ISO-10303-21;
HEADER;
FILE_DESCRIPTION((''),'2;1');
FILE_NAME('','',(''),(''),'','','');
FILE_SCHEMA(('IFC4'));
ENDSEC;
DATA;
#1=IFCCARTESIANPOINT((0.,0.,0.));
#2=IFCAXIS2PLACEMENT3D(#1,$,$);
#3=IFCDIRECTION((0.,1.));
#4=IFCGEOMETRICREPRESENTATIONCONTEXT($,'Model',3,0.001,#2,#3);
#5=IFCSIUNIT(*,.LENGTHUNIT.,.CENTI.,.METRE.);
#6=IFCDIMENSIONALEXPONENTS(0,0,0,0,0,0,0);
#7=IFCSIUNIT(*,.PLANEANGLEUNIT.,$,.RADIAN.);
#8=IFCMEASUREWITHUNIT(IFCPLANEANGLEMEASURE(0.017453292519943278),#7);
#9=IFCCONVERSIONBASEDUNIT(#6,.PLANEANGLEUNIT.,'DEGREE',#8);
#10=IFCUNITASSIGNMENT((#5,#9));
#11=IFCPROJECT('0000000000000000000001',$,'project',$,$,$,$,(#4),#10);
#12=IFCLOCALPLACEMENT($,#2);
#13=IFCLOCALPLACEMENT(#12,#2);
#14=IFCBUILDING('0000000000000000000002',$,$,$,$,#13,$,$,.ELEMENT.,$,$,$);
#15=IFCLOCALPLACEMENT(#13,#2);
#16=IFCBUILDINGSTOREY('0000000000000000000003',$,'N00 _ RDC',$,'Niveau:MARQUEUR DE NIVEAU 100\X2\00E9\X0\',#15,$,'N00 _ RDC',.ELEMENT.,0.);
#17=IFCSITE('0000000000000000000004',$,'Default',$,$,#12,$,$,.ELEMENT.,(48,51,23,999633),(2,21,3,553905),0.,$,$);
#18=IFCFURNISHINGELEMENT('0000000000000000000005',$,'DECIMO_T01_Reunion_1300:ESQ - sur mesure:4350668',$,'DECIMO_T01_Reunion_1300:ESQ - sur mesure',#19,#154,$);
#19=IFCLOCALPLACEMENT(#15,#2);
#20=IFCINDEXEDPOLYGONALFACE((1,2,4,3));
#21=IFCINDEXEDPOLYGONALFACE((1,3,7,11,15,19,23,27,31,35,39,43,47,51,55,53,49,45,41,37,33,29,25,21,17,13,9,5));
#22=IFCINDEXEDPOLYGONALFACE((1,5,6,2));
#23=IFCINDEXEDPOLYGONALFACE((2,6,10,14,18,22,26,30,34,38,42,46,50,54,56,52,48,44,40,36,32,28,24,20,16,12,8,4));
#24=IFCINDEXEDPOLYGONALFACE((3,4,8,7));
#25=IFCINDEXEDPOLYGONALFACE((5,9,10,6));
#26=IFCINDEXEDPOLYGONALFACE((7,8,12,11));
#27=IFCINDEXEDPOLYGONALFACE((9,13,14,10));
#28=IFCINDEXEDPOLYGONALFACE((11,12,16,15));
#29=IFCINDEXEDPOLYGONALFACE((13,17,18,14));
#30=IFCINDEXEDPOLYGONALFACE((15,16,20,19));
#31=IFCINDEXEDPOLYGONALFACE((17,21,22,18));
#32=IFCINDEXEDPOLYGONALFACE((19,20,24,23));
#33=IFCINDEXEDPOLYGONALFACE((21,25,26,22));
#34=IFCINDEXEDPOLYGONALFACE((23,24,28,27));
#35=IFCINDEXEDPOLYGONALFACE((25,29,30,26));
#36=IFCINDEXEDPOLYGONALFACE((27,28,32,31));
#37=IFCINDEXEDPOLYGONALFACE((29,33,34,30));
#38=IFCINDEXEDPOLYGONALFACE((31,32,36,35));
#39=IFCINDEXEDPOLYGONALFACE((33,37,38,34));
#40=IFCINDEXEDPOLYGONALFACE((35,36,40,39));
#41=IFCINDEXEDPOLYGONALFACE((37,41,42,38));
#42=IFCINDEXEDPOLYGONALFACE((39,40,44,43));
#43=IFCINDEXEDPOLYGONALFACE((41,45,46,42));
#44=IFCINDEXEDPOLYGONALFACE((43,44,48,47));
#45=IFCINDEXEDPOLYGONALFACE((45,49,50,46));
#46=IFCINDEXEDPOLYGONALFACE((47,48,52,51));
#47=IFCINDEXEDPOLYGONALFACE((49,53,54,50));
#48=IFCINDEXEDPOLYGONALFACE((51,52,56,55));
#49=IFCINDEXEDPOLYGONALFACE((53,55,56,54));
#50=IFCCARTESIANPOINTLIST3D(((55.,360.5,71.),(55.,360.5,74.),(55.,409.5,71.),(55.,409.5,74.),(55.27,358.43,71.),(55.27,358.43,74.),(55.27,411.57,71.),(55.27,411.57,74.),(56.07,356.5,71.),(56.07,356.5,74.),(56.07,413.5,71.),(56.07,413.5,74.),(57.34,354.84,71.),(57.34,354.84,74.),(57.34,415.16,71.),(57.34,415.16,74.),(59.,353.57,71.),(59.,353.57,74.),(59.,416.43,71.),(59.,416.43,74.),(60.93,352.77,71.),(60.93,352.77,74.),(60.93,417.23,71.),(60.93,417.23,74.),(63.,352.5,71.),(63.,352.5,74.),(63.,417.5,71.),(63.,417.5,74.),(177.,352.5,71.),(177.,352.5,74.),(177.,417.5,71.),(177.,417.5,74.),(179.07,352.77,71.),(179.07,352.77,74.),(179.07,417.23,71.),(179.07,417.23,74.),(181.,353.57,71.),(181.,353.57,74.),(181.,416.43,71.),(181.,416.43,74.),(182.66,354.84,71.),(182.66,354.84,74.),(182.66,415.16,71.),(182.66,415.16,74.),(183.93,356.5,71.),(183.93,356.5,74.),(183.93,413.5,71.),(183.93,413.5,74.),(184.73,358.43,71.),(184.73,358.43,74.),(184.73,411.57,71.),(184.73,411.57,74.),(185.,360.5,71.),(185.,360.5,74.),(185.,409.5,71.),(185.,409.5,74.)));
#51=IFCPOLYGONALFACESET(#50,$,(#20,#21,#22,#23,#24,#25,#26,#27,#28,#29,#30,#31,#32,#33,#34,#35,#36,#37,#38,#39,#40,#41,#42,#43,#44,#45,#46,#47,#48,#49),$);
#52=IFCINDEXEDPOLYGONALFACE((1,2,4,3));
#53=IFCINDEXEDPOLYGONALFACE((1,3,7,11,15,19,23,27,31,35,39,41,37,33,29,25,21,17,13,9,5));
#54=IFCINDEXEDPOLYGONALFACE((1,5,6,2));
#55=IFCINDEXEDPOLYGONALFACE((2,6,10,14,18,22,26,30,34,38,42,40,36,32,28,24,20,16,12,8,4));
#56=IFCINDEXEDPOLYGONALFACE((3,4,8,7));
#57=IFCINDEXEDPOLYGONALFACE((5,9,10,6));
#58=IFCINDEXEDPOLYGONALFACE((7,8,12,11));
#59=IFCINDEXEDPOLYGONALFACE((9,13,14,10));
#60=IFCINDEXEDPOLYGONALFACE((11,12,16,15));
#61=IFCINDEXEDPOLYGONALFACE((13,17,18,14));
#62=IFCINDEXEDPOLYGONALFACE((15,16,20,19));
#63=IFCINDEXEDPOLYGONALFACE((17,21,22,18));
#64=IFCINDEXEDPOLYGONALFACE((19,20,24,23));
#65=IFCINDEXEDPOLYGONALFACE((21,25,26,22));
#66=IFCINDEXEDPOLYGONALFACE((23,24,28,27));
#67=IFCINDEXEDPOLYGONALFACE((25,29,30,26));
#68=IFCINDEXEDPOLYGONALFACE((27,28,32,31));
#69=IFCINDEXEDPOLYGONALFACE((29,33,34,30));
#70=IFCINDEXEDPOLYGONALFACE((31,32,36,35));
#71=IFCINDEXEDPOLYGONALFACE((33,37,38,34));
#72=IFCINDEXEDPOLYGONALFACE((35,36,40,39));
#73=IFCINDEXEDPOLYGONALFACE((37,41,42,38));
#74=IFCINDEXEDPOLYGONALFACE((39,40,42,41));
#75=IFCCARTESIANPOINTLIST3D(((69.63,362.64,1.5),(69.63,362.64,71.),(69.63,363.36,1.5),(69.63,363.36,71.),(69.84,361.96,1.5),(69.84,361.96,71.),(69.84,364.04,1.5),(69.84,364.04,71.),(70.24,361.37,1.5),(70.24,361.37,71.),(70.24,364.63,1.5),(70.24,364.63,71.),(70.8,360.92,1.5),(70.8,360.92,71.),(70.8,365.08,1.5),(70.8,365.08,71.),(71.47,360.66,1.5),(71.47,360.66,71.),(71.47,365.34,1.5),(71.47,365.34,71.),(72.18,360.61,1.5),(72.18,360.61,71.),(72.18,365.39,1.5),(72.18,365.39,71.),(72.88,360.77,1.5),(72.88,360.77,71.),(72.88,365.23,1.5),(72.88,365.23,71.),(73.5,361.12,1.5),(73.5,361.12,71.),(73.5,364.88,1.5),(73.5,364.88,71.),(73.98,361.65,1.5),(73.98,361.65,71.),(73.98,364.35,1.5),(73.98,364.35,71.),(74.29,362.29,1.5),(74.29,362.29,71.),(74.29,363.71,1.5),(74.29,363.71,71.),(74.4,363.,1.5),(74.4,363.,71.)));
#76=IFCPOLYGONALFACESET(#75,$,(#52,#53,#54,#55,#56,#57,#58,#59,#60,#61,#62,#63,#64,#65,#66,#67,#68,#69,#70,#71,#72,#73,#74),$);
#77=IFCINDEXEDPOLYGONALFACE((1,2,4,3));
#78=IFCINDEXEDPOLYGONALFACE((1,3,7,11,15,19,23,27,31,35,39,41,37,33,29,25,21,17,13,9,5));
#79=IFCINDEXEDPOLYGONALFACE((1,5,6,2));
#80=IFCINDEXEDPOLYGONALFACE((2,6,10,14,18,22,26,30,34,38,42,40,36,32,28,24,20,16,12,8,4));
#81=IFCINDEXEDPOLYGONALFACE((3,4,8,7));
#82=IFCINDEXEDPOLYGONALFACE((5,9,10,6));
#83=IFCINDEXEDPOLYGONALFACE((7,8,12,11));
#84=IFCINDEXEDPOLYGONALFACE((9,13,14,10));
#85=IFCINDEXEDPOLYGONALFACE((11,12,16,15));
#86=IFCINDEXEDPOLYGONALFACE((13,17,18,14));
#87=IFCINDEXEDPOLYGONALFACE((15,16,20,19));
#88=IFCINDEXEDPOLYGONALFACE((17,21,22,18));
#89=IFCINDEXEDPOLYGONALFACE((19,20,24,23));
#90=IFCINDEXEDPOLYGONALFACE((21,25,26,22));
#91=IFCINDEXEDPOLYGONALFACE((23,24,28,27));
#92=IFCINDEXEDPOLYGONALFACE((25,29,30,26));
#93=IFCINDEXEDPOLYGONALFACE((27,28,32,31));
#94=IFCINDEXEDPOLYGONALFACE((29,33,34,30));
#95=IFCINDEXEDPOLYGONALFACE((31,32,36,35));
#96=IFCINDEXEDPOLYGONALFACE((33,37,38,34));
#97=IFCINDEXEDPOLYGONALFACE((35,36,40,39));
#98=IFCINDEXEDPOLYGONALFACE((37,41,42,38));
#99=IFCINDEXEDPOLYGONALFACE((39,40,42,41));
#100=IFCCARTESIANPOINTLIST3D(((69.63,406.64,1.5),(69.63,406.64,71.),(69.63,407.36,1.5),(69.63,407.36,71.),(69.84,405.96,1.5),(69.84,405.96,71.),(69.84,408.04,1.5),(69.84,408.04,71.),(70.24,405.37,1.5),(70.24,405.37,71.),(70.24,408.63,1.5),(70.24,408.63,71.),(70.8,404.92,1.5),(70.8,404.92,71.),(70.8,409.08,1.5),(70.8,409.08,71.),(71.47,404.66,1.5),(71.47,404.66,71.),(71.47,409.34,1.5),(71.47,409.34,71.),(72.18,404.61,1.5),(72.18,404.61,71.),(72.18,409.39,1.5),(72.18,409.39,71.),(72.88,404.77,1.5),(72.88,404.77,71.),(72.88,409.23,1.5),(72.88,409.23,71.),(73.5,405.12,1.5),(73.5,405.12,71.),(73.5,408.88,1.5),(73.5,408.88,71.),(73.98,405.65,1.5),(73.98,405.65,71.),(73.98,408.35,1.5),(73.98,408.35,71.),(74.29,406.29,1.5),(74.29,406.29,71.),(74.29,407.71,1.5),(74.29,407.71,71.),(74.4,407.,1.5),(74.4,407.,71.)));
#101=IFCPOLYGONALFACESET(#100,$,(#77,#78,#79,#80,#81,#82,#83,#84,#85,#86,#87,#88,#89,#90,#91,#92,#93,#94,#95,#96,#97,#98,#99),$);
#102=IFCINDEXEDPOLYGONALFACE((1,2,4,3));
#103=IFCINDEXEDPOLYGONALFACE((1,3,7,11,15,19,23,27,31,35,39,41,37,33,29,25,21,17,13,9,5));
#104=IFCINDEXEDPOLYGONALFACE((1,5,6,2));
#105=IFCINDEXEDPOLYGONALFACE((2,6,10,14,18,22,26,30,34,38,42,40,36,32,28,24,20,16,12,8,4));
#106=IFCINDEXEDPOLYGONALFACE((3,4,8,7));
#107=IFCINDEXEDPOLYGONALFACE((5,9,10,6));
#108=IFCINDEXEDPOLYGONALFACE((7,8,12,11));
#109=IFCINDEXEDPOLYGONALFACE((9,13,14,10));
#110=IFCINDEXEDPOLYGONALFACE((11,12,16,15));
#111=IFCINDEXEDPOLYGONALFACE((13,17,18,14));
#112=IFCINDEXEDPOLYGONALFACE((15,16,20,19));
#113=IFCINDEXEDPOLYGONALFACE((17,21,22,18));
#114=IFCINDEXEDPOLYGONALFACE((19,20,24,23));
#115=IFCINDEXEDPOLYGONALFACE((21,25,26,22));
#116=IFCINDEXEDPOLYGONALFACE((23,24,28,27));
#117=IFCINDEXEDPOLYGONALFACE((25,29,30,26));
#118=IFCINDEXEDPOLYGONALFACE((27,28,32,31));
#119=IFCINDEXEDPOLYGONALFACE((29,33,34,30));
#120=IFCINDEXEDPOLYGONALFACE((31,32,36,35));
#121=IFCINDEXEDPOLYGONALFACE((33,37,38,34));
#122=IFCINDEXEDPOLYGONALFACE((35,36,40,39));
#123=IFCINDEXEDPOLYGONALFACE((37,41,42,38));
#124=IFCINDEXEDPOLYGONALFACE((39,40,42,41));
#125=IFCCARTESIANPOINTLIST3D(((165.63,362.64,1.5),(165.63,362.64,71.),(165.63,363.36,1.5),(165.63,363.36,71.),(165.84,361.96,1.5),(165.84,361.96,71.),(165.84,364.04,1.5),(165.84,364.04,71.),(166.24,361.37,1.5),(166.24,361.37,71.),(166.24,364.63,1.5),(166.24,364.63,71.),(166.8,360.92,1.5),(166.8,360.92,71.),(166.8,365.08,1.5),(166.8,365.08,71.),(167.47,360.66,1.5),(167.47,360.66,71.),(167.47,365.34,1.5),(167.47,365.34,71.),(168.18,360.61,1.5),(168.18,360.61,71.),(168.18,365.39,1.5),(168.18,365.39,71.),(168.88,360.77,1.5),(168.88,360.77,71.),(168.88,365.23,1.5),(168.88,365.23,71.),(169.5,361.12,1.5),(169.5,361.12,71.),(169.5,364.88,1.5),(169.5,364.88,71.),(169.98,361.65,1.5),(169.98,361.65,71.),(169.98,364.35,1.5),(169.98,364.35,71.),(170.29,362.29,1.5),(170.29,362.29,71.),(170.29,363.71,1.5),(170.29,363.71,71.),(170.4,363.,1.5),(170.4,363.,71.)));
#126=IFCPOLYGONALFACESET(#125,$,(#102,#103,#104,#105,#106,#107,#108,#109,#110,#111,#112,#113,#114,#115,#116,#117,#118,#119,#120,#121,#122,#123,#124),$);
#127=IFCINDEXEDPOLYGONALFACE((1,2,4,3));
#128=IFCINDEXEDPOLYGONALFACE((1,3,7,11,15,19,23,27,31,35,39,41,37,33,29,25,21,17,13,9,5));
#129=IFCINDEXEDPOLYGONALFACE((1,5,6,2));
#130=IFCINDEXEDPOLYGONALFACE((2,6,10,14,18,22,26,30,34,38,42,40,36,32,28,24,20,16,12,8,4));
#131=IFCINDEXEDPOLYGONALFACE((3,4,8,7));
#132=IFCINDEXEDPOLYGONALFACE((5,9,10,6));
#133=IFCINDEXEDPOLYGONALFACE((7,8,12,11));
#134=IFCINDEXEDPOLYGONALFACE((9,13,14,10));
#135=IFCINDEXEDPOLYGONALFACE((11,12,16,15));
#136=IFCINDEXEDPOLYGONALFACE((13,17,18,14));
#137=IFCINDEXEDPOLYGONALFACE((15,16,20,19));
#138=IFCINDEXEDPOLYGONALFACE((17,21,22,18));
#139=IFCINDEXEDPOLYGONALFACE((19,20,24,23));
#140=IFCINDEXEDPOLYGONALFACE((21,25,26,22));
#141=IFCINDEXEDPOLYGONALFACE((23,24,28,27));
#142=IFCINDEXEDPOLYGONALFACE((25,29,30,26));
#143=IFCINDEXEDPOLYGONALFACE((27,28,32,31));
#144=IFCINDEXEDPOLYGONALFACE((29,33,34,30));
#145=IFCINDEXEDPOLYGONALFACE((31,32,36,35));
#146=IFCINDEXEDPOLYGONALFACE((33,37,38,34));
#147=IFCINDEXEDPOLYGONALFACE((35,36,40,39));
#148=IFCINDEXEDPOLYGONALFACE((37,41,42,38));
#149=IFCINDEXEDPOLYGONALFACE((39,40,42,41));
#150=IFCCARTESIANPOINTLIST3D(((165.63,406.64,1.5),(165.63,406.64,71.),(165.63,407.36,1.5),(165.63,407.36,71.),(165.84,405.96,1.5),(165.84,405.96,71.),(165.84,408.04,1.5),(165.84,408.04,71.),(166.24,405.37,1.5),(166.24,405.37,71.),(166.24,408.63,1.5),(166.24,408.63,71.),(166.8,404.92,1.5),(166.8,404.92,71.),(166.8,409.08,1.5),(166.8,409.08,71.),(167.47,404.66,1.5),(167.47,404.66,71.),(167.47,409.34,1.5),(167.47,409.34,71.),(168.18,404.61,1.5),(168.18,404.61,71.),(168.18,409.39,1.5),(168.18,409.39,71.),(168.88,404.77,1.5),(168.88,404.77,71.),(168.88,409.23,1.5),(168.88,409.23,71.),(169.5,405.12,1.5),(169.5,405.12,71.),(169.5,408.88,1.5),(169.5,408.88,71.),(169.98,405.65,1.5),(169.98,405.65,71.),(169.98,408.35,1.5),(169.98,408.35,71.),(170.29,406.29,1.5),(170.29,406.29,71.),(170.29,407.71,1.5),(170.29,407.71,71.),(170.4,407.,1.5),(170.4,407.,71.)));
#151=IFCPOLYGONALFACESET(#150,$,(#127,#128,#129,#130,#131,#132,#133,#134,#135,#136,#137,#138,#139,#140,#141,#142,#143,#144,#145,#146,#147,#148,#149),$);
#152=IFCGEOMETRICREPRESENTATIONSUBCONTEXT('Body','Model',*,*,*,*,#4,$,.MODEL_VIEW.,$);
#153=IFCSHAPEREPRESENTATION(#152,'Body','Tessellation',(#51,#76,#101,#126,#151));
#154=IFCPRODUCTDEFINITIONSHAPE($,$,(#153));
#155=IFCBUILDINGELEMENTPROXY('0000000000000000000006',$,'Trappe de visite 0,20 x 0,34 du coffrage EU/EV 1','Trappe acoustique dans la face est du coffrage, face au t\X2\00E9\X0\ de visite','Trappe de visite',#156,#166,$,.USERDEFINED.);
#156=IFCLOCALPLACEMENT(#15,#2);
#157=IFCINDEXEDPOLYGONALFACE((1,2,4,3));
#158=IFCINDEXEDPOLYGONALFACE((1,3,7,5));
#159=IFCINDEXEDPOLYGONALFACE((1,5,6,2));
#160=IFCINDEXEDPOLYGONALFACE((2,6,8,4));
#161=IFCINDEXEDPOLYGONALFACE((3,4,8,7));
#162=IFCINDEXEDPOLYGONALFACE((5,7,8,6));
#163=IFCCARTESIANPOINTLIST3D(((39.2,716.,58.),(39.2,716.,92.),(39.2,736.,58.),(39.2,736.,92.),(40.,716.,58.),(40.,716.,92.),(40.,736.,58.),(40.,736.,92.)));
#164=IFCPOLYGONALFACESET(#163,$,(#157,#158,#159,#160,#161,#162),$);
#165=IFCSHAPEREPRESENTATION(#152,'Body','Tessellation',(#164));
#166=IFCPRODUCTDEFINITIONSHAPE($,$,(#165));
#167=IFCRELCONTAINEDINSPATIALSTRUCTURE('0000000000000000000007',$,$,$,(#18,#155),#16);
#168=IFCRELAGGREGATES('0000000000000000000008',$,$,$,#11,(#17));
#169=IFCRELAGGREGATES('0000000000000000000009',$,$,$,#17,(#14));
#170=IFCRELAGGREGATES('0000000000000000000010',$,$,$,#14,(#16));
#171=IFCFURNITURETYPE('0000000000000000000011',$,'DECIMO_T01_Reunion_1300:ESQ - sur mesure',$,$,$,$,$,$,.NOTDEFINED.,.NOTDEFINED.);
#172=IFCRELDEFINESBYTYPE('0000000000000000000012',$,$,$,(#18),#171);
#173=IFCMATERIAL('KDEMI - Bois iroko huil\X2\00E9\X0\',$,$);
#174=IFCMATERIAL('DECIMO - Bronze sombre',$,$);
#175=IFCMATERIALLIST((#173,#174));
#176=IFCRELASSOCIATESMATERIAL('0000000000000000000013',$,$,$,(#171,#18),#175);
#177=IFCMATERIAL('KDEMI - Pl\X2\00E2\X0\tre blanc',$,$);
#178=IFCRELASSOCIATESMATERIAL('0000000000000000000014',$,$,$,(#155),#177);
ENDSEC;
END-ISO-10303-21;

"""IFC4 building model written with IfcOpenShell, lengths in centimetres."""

from ifc_helpers import new_model, entity, si_unit, converted_unit, direction, frame, frame_2d, origin, origin_with_axes, origin_2d_with_axis, place, context, subcontext, project, spatial, polyline, circle_curve, parameter, trimmed, segment, composite_curve, rectangle, circle, outline, extrude, source, transform, mapped, material, material_list, type_object, type_shapes, element, save


model = new_model("IFC4")

# Units and contexts
model_context = context("Model", 3, precision=0.001, world=origin(), true_north=direction((0.0, 1.0)))
body_context = subcontext(model_context, "Body", "Model", "MODEL_VIEW")
ifc_project = project(units=[si_unit("LENGTHUNIT", "METRE", prefix="CENTI"), converted_unit("PLANEANGLEUNIT", "DEGREE", entity("IfcPlaneAngleMeasure", 0.017453292519943278), si_unit("PLANEANGLEUNIT", "RADIAN"), dimensions=[0, 0, 0, 0, 0, 0, 0])], contexts=[model_context])

# Site, building, storey
site_placement = place(None, origin())
site = spatial("IfcSite", under=ifc_project, at=site_placement, Name="Default", CompositionType="ELEMENT", RefLatitude=(48, 51, 23, 999633), RefLongitude=(2, 21, 3, 553905), RefElevation=0.0)
building_placement = place(site_placement, origin())
building = spatial("IfcBuilding", under=site, at=building_placement, CompositionType="ELEMENT")
storey_placement = place(building_placement, origin())
storey = spatial("IfcBuildingStorey", under=building, at=storey_placement, Name="N00 _ RDC", ObjectType="Niveau:MARQUEUR DE NIVEAU 100é", LongName="N00 _ RDC", CompositionType="ELEMENT", Elevation=0.0)

# Furnishing element
ifc_material_1 = material(Name="KDEMI - Bois iroko huilé")
ifc_material_2 = material(Name="DECIMO - Bronze sombre")
ifc_material_list_1 = material_list([ifc_material_1, ifc_material_2])
furniture_type_1 = type_object("IfcFurnitureType", Name="DECIMO_T01_Reunion_1300:ESQ - sur mesure", AssemblyPlace="NOTDEFINED", material=ifc_material_list_1)
shared_shape_1 = source(origin(), body_context, "Body", "SweptSolid", [
    extrude(outline(composite_curve([segment(polyline([(-57.0, -32.5), (57.0, -32.5)]), True, "CONTINUOUS"), segment(trimmed(circle_curve(frame_2d((57.0, -24.5), x_axis=(1.0, 0.0)), 8.0), [parameter(270.0)], [parameter(0.0)], True, "PARAMETER"), True, "CONTINUOUS"), segment(polyline([(65.0, -24.5), (65.0, 24.5)]), True, "CONTINUOUS"), segment(trimmed(circle_curve(frame_2d((57.0, 24.5), x_axis=(1.0, 0.0)), 8.0), [parameter(0.0)], [parameter(90.0)], True, "PARAMETER"), True, "CONTINUOUS"), segment(polyline([(57.0, 32.5), (-57.0, 32.5)]), True, "CONTINUOUS"), segment(trimmed(circle_curve(frame_2d((-57.0, 24.5), x_axis=(1.0, 0.0)), 8.0), [parameter(90.0)], [parameter(180.0)], True, "PARAMETER"), True, "CONTINUOUS"), segment(polyline([(-65.0, 24.5), (-65.0, -24.5)]), True, "CONTINUOUS"), segment(trimmed(circle_curve(frame_2d((-57.0, -24.5), x_axis=(1.0, 0.0)), 8.0), [parameter(180.0)], [parameter(270.0)], True, "PARAMETER"), True, "CONTINUOUS")], self_intersect=False)), frame((0.0, 0.0, 71.0)), (0.0, 0.0, 1.0), 3.0),
    extrude(circle(Radius=2.4, at=origin_2d_with_axis()), frame((-48.0, -22.0, 1.5)), (0.0, 0.0, 1.0), 69.5),
    extrude(circle(Radius=2.4, at=origin_2d_with_axis()), frame((-48.0, 22.0, 1.5)), (0.0, 0.0, 1.0), 69.5),
    extrude(circle(Radius=2.4, at=origin_2d_with_axis()), frame((48.0, -22.0, 1.5)), (0.0, 0.0, 1.0), 69.5),
    extrude(circle(Radius=2.4, at=origin_2d_with_axis()), frame((48.0, 22.0, 1.5)), (0.0, 0.0, 1.0), 69.5),
])
type_shapes(furniture_type_1, [shared_shape_1])
furnishing_1_placement = place(storey_placement, frame((120.0, 385.0, 0.0)))
element("IfcFurnishingElement", 1, at=furnishing_1_placement, inside=storey, type_object=furniture_type_1, material=ifc_material_list_1, Name="DECIMO_T01_Reunion_1300:ESQ - sur mesure:4350668", ObjectType="DECIMO_T01_Reunion_1300:ESQ - sur mesure", context=body_context, shape_type="MappedRepresentation", body=[
    mapped(shared_shape_1, transform((0.0, 0.0, 0.0), scale=1.0)),
])

# Building element proxy
ifc_material_3 = material(Name="KDEMI - Plâtre blanc")
proxy_1_placement = place(storey_placement, origin_with_axes())
element("IfcBuildingElementProxy", 2, at=proxy_1_placement, inside=storey, material=ifc_material_3, Name="Trappe de visite 0,20 x 0,34 du coffrage EU/EV 1", Description="Trappe acoustique dans la face est du coffrage, face au té de visite", ObjectType="Trappe de visite", PredefinedType="USERDEFINED", context=body_context, shape_type="SweptSolid", body=[
    extrude(rectangle(XDim=0.8, YDim=20.0, at=frame_2d((39.6, 726.0))), frame((0.0, 0.0, 58.0)), (0.0, 0.0, 1.0), 34.0),
])

save(model, "model.ifc")
